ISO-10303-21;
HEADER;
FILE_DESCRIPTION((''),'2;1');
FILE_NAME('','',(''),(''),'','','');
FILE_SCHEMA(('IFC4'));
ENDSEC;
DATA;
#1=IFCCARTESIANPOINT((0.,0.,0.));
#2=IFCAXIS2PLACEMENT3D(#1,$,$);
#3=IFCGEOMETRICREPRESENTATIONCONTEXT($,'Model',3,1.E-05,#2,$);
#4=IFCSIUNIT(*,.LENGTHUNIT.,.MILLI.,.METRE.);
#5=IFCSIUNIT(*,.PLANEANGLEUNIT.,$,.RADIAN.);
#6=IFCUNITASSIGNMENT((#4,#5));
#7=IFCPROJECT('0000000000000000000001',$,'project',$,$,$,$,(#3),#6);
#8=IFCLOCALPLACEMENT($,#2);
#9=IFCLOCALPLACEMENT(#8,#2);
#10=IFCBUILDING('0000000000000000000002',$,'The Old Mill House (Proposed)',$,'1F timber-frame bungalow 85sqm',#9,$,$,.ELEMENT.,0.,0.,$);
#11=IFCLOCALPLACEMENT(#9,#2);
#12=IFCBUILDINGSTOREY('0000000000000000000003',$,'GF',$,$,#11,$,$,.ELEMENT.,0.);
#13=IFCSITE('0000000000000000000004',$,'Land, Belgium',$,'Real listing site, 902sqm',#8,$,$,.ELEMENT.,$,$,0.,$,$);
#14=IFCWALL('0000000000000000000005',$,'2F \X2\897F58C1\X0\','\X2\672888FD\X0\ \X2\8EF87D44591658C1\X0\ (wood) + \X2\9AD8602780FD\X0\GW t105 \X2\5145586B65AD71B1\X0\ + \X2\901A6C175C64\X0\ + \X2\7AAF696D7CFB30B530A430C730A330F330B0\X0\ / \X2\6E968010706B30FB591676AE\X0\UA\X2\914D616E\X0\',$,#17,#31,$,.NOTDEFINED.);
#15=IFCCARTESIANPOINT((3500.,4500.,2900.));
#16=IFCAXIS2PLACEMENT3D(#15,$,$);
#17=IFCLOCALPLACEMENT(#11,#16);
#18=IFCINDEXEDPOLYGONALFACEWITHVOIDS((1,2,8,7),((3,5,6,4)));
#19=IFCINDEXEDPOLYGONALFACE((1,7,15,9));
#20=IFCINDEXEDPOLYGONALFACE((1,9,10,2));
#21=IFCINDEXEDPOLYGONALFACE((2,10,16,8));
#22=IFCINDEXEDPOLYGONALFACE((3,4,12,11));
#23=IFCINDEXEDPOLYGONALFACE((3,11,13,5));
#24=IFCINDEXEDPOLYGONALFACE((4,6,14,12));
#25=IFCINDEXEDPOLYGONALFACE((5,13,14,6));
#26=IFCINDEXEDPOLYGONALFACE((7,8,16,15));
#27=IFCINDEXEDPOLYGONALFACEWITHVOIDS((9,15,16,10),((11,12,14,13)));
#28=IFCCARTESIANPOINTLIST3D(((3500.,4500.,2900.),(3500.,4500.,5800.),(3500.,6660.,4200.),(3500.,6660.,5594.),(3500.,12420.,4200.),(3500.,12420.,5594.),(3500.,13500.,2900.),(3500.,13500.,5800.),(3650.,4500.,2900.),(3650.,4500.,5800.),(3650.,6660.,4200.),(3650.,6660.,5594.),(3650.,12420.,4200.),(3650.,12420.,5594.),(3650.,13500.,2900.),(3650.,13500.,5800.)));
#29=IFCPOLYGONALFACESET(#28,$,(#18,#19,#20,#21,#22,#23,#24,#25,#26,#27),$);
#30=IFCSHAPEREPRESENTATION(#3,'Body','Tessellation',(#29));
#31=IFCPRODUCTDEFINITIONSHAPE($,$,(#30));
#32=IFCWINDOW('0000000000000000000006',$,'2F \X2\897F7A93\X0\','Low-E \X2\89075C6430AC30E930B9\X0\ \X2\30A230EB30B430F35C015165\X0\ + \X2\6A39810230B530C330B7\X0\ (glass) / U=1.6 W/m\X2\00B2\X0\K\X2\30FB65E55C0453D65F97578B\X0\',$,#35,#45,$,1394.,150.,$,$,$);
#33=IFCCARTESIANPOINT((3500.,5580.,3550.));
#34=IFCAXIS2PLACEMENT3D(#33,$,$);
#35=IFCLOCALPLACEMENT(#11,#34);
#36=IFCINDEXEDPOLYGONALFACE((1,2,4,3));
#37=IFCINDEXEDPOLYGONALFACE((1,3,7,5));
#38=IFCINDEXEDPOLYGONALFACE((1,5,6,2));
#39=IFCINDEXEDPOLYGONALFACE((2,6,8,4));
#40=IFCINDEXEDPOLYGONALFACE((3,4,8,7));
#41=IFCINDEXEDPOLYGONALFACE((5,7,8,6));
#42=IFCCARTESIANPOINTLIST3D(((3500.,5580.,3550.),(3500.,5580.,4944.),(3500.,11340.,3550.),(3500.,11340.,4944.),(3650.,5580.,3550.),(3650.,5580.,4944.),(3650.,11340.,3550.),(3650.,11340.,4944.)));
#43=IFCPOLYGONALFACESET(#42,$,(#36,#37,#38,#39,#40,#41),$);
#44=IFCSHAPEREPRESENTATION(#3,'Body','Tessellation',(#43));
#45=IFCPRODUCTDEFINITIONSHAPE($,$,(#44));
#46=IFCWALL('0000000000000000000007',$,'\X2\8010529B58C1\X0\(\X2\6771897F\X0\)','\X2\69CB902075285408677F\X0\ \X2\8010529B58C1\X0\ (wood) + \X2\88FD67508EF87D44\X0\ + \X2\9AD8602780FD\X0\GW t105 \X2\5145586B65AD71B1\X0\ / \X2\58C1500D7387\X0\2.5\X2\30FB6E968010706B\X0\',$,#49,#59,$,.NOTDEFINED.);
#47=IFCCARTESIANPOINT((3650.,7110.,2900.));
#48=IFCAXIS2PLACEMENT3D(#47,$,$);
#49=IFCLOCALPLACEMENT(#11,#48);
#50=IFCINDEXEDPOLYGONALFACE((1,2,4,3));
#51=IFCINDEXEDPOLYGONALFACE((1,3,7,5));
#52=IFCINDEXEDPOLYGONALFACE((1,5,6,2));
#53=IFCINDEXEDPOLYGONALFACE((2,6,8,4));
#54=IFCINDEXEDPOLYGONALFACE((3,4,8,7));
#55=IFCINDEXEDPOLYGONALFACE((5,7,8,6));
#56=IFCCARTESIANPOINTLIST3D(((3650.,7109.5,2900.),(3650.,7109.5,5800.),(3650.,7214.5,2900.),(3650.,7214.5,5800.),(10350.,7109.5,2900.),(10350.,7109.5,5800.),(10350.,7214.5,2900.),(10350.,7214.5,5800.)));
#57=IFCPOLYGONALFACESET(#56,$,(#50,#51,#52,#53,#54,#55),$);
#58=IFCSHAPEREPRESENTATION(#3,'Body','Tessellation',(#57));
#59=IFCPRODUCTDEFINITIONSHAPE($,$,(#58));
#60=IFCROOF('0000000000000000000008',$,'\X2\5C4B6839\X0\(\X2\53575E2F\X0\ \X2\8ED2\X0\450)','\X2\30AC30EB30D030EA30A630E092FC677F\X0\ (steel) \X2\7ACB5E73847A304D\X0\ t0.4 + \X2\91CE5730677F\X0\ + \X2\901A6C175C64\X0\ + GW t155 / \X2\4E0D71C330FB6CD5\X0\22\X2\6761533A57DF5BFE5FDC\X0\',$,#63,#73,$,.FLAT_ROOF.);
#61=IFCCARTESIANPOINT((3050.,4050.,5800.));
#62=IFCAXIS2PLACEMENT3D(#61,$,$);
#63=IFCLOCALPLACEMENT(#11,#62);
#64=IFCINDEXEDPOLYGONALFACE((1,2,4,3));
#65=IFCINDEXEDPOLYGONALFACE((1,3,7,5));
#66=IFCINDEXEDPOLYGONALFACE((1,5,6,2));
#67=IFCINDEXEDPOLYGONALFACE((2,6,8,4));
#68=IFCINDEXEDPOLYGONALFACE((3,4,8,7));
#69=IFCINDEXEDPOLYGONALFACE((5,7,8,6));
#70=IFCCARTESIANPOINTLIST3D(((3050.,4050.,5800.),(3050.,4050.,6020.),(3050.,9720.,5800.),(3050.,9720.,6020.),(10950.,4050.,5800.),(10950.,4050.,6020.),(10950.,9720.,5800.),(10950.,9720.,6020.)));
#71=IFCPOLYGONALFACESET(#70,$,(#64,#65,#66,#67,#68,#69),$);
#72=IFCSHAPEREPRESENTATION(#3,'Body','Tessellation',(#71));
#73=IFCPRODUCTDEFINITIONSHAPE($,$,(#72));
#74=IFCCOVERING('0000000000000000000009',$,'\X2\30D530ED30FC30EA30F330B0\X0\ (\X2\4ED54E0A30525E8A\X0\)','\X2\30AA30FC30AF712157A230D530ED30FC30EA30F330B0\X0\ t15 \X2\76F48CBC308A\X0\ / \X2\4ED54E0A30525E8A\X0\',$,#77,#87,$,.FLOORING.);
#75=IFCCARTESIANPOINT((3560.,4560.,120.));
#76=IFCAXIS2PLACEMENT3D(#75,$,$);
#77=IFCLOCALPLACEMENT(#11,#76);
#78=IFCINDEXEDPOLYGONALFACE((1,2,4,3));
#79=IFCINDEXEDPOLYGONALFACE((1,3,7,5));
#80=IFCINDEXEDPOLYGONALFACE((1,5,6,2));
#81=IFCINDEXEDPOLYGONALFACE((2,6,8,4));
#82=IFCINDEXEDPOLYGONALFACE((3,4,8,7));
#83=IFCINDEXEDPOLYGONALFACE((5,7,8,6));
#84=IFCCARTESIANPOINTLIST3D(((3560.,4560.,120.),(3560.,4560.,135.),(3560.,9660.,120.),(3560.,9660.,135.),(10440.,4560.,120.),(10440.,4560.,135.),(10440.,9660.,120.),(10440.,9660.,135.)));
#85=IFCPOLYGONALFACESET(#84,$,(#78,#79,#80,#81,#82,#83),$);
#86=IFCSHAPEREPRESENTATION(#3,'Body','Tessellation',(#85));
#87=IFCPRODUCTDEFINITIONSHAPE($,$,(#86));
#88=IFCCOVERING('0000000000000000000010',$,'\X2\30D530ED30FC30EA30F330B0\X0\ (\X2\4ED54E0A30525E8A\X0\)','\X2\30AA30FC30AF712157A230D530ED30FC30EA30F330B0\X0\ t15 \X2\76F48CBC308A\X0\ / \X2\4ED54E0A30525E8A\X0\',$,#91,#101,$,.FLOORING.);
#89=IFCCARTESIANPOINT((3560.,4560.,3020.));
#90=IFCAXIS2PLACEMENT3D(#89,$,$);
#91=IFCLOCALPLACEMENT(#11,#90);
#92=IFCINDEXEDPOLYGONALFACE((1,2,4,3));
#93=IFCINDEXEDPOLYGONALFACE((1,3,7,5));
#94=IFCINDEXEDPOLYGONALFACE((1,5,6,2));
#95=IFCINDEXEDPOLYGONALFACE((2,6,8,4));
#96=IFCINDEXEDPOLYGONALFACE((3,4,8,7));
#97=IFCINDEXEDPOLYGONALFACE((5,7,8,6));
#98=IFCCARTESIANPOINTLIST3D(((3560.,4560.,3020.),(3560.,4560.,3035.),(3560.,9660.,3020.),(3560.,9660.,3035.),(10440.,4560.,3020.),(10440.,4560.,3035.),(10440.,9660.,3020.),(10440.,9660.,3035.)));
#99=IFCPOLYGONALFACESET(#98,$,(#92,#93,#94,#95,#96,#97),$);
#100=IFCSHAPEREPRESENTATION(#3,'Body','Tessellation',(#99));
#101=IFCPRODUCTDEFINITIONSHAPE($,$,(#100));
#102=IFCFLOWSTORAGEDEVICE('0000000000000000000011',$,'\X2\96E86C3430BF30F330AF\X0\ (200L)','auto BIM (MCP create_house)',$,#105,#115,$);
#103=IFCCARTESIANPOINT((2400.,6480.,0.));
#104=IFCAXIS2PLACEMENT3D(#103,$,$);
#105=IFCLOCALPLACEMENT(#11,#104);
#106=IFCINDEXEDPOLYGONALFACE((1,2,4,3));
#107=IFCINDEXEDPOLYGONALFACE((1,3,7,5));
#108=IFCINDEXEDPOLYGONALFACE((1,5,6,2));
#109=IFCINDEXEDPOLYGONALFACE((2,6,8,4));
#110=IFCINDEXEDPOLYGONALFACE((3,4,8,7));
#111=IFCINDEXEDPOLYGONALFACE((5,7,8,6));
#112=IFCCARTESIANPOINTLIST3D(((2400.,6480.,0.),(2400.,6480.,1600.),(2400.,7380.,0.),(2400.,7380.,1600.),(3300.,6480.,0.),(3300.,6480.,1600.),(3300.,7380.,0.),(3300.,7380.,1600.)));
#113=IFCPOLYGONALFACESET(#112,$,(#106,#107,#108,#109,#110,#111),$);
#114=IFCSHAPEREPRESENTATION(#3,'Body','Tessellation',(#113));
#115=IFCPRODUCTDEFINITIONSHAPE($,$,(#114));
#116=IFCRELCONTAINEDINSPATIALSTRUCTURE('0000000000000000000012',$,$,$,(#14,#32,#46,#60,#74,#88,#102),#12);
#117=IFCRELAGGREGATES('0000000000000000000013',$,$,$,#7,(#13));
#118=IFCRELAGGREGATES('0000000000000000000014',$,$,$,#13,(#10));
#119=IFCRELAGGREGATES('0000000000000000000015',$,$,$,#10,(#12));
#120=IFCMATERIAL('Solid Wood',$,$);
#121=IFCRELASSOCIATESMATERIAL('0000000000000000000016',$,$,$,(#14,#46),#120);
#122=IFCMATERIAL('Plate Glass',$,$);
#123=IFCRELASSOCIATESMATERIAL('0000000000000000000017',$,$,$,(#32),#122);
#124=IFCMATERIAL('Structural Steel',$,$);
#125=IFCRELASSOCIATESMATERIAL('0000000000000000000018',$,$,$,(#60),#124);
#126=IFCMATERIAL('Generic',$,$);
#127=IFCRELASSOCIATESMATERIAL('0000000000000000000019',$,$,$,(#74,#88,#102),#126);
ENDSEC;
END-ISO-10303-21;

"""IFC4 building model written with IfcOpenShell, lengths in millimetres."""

from ifc_helpers import new_model, si_unit, frame, frame_2d, origin, place, context, project, spatial, rectangle, extrude, material, element, fill, save


model = new_model("IFC4")

# Units and contexts
model_context = context("Model", 3, precision=1e-05, world=origin())
ifc_project = project(units=[si_unit("LENGTHUNIT", "METRE", prefix="MILLI"), si_unit("PLANEANGLEUNIT", "RADIAN")], contexts=[model_context])

# Site, building, storey
site_placement = place(None, origin())
site = spatial("IfcSite", under=ifc_project, at=site_placement, Name="Land, Belgium", ObjectType="Real listing site, 902sqm", CompositionType="ELEMENT", RefElevation=0.0)
building_placement = place(site_placement, origin())
building = spatial("IfcBuilding", under=site, at=building_placement, Name="The Old Mill House (Proposed)", ObjectType="1F timber-frame bungalow 85sqm", CompositionType="ELEMENT", ElevationOfRefHeight=0.0, ElevationOfTerrain=0.0)
storey_placement = place(building_placement, origin())
storey = spatial("IfcBuildingStorey", under=building, at=storey_placement, Name="GF", CompositionType="ELEMENT", Elevation=0.0)

# Shared definitions
ifc_material_1 = material(Name="Solid Wood")
ifc_material_2 = material(Name="Generic")

# Shared definitions
ifc_material_3 = material(Name="Plate Glass")

# Wall, opening, window
wall_1_placement = place(storey_placement, frame((3500.0, 4500.0, 2900.0)))
wall_1 = element("IfcWall", 1, at=wall_1_placement, inside=storey, material=ifc_material_1, Name="2F 西壁", Description="木製 軸組外壁 (wood) + 高性能GW t105 充填断熱 + 通気層 + 窯業系サイディング / 準耐火・外皮UA配慮", PredefinedType="NOTDEFINED", context=model_context, shape_type="SweptSolid", body=[
    extrude(rectangle(XDim=150.0, YDim=9000.0, at=frame_2d((75.0, 4500.0))), frame((3500.0, 4500.0, 2900.0)), (0.0, 0.0, 1.0), 2900.0),
])
opening_1_placement = place(storey_placement, frame((3500.0, 5580.0, 3550.0)))
opening_1 = element("IfcOpeningElement", 2, at=opening_1_placement, cuts=wall_1, PredefinedType="NOTDEFINED", context=model_context, shape_type="SweptSolid", body=[
    extrude(rectangle(XDim=150.0, YDim=5760.0, at=frame_2d((75.0, 2880.0))), frame((3500.0, 5580.0, 3550.0)), (0.0, 0.0, 1.0), 1394.0),
])
window_1_placement = place(storey_placement, frame((3500.0, 5580.0, 3550.0)))
window_1 = element("IfcWindow", 3, at=window_1_placement, inside=storey, material=ifc_material_3, Name="2F 西窓", Description="Low-E 複層ガラス アルゴン封入 + 樹脂サッシ (glass) / U=1.6 W/m²K・日射取得型", OverallHeight=1394.0, OverallWidth=150.0, context=model_context, shape_type="SweptSolid", body=[
    extrude(rectangle(XDim=150.0, YDim=5760.0, at=frame_2d((75.0, 2880.0))), frame((3500.0, 5580.0, 3550.0)), (0.0, 0.0, 1.0), 1394.0),
])
fill(opening_1, window_1)

# Wall
wall_2_placement = place(storey_placement, frame((3650.0, 7110.0, 2900.0)))
element("IfcWall", 4, at=wall_2_placement, inside=storey, material=ifc_material_1, Name="耐力壁(東西)", Description="構造用合板 耐力壁 (wood) + 製材軸組 + 高性能GW t105 充填断熱 / 壁倍率2.5・準耐火", PredefinedType="NOTDEFINED", context=model_context, shape_type="SweptSolid", body=[
    extrude(rectangle(XDim=6700.0, YDim=105.0, at=frame_2d((3350.0, 52.0))), frame((3650.0, 7110.0, 2900.0)), (0.0, 0.0, 1.0), 2900.0),
])

# Roof
ifc_material_4 = material(Name="Structural Steel")
for number, where, name in (
    (5, (3050.0, 4050.0, 5800.0), "屋根(南帯 軒450)"),
):
    element("IfcRoof", number, at=place(storey_placement, frame(where)), inside=storey, material=ifc_material_4, Name=name, Description="ガルバリウム鋼板 (steel) 立平葺き t0.4 + 野地板 + 通気層 + GW t155 / 不燃・法22条区域対応", PredefinedType="FLAT_ROOF", context=model_context, shape_type="SweptSolid", body=[
        extrude(rectangle(XDim=7900.0, YDim=5670.0, at=frame_2d((3950.0, 2835.0))), frame((3050.0, 4050.0, 5800.0)), (0.0, 0.0, 1.0), 220.0),
    ])

# Coverings
covering_1_placement = place(storey_placement, frame((3560.0, 4560.0, 120.0)))
element("IfcCovering", 6, at=covering_1_placement, inside=storey, material=ifc_material_2, Name="フローリング (仕上げ床)", Description="オーク無垢フローリング t15 直貼り / 仕上げ床", PredefinedType="FLOORING", context=model_context, shape_type="SweptSolid", body=[
    extrude(rectangle(XDim=6880.0, YDim=5100.0, at=frame_2d((3440.0, 2550.0))), frame((3560.0, 4560.0, 120.0)), (0.0, 0.0, 1.0), 15.0),
])
covering_2_placement = place(storey_placement, frame((3560.0, 4560.0, 3020.0)))
element("IfcCovering", 7, at=covering_2_placement, inside=storey, material=ifc_material_2, Name="フローリング (仕上げ床)", Description="オーク無垢フローリング t15 直貼り / 仕上げ床", PredefinedType="FLOORING", context=model_context, shape_type="SweptSolid", body=[
    extrude(rectangle(XDim=6880.0, YDim=5100.0, at=frame_2d((3440.0, 2550.0))), frame((3560.0, 4560.0, 3020.0)), (0.0, 0.0, 1.0), 15.0),
])

# Flow storage device
flow_storage_device_placement = place(storey_placement, frame((2400.0, 6480.0, 0.0)))
element("IfcFlowStorageDevice", 8, at=flow_storage_device_placement, inside=storey, material=ifc_material_2, Name="雨水タンク (200L)", Description="auto BIM (MCP create_house)", context=model_context, shape_type="SweptSolid", body=[
    extrude(rectangle(XDim=900.0, YDim=900.0, at=frame_2d((450.0, 450.0))), frame((2400.0, 6480.0, 0.0)), (0.0, 0.0, 1.0), 1600.0),
])

save(model, "model.ifc")
